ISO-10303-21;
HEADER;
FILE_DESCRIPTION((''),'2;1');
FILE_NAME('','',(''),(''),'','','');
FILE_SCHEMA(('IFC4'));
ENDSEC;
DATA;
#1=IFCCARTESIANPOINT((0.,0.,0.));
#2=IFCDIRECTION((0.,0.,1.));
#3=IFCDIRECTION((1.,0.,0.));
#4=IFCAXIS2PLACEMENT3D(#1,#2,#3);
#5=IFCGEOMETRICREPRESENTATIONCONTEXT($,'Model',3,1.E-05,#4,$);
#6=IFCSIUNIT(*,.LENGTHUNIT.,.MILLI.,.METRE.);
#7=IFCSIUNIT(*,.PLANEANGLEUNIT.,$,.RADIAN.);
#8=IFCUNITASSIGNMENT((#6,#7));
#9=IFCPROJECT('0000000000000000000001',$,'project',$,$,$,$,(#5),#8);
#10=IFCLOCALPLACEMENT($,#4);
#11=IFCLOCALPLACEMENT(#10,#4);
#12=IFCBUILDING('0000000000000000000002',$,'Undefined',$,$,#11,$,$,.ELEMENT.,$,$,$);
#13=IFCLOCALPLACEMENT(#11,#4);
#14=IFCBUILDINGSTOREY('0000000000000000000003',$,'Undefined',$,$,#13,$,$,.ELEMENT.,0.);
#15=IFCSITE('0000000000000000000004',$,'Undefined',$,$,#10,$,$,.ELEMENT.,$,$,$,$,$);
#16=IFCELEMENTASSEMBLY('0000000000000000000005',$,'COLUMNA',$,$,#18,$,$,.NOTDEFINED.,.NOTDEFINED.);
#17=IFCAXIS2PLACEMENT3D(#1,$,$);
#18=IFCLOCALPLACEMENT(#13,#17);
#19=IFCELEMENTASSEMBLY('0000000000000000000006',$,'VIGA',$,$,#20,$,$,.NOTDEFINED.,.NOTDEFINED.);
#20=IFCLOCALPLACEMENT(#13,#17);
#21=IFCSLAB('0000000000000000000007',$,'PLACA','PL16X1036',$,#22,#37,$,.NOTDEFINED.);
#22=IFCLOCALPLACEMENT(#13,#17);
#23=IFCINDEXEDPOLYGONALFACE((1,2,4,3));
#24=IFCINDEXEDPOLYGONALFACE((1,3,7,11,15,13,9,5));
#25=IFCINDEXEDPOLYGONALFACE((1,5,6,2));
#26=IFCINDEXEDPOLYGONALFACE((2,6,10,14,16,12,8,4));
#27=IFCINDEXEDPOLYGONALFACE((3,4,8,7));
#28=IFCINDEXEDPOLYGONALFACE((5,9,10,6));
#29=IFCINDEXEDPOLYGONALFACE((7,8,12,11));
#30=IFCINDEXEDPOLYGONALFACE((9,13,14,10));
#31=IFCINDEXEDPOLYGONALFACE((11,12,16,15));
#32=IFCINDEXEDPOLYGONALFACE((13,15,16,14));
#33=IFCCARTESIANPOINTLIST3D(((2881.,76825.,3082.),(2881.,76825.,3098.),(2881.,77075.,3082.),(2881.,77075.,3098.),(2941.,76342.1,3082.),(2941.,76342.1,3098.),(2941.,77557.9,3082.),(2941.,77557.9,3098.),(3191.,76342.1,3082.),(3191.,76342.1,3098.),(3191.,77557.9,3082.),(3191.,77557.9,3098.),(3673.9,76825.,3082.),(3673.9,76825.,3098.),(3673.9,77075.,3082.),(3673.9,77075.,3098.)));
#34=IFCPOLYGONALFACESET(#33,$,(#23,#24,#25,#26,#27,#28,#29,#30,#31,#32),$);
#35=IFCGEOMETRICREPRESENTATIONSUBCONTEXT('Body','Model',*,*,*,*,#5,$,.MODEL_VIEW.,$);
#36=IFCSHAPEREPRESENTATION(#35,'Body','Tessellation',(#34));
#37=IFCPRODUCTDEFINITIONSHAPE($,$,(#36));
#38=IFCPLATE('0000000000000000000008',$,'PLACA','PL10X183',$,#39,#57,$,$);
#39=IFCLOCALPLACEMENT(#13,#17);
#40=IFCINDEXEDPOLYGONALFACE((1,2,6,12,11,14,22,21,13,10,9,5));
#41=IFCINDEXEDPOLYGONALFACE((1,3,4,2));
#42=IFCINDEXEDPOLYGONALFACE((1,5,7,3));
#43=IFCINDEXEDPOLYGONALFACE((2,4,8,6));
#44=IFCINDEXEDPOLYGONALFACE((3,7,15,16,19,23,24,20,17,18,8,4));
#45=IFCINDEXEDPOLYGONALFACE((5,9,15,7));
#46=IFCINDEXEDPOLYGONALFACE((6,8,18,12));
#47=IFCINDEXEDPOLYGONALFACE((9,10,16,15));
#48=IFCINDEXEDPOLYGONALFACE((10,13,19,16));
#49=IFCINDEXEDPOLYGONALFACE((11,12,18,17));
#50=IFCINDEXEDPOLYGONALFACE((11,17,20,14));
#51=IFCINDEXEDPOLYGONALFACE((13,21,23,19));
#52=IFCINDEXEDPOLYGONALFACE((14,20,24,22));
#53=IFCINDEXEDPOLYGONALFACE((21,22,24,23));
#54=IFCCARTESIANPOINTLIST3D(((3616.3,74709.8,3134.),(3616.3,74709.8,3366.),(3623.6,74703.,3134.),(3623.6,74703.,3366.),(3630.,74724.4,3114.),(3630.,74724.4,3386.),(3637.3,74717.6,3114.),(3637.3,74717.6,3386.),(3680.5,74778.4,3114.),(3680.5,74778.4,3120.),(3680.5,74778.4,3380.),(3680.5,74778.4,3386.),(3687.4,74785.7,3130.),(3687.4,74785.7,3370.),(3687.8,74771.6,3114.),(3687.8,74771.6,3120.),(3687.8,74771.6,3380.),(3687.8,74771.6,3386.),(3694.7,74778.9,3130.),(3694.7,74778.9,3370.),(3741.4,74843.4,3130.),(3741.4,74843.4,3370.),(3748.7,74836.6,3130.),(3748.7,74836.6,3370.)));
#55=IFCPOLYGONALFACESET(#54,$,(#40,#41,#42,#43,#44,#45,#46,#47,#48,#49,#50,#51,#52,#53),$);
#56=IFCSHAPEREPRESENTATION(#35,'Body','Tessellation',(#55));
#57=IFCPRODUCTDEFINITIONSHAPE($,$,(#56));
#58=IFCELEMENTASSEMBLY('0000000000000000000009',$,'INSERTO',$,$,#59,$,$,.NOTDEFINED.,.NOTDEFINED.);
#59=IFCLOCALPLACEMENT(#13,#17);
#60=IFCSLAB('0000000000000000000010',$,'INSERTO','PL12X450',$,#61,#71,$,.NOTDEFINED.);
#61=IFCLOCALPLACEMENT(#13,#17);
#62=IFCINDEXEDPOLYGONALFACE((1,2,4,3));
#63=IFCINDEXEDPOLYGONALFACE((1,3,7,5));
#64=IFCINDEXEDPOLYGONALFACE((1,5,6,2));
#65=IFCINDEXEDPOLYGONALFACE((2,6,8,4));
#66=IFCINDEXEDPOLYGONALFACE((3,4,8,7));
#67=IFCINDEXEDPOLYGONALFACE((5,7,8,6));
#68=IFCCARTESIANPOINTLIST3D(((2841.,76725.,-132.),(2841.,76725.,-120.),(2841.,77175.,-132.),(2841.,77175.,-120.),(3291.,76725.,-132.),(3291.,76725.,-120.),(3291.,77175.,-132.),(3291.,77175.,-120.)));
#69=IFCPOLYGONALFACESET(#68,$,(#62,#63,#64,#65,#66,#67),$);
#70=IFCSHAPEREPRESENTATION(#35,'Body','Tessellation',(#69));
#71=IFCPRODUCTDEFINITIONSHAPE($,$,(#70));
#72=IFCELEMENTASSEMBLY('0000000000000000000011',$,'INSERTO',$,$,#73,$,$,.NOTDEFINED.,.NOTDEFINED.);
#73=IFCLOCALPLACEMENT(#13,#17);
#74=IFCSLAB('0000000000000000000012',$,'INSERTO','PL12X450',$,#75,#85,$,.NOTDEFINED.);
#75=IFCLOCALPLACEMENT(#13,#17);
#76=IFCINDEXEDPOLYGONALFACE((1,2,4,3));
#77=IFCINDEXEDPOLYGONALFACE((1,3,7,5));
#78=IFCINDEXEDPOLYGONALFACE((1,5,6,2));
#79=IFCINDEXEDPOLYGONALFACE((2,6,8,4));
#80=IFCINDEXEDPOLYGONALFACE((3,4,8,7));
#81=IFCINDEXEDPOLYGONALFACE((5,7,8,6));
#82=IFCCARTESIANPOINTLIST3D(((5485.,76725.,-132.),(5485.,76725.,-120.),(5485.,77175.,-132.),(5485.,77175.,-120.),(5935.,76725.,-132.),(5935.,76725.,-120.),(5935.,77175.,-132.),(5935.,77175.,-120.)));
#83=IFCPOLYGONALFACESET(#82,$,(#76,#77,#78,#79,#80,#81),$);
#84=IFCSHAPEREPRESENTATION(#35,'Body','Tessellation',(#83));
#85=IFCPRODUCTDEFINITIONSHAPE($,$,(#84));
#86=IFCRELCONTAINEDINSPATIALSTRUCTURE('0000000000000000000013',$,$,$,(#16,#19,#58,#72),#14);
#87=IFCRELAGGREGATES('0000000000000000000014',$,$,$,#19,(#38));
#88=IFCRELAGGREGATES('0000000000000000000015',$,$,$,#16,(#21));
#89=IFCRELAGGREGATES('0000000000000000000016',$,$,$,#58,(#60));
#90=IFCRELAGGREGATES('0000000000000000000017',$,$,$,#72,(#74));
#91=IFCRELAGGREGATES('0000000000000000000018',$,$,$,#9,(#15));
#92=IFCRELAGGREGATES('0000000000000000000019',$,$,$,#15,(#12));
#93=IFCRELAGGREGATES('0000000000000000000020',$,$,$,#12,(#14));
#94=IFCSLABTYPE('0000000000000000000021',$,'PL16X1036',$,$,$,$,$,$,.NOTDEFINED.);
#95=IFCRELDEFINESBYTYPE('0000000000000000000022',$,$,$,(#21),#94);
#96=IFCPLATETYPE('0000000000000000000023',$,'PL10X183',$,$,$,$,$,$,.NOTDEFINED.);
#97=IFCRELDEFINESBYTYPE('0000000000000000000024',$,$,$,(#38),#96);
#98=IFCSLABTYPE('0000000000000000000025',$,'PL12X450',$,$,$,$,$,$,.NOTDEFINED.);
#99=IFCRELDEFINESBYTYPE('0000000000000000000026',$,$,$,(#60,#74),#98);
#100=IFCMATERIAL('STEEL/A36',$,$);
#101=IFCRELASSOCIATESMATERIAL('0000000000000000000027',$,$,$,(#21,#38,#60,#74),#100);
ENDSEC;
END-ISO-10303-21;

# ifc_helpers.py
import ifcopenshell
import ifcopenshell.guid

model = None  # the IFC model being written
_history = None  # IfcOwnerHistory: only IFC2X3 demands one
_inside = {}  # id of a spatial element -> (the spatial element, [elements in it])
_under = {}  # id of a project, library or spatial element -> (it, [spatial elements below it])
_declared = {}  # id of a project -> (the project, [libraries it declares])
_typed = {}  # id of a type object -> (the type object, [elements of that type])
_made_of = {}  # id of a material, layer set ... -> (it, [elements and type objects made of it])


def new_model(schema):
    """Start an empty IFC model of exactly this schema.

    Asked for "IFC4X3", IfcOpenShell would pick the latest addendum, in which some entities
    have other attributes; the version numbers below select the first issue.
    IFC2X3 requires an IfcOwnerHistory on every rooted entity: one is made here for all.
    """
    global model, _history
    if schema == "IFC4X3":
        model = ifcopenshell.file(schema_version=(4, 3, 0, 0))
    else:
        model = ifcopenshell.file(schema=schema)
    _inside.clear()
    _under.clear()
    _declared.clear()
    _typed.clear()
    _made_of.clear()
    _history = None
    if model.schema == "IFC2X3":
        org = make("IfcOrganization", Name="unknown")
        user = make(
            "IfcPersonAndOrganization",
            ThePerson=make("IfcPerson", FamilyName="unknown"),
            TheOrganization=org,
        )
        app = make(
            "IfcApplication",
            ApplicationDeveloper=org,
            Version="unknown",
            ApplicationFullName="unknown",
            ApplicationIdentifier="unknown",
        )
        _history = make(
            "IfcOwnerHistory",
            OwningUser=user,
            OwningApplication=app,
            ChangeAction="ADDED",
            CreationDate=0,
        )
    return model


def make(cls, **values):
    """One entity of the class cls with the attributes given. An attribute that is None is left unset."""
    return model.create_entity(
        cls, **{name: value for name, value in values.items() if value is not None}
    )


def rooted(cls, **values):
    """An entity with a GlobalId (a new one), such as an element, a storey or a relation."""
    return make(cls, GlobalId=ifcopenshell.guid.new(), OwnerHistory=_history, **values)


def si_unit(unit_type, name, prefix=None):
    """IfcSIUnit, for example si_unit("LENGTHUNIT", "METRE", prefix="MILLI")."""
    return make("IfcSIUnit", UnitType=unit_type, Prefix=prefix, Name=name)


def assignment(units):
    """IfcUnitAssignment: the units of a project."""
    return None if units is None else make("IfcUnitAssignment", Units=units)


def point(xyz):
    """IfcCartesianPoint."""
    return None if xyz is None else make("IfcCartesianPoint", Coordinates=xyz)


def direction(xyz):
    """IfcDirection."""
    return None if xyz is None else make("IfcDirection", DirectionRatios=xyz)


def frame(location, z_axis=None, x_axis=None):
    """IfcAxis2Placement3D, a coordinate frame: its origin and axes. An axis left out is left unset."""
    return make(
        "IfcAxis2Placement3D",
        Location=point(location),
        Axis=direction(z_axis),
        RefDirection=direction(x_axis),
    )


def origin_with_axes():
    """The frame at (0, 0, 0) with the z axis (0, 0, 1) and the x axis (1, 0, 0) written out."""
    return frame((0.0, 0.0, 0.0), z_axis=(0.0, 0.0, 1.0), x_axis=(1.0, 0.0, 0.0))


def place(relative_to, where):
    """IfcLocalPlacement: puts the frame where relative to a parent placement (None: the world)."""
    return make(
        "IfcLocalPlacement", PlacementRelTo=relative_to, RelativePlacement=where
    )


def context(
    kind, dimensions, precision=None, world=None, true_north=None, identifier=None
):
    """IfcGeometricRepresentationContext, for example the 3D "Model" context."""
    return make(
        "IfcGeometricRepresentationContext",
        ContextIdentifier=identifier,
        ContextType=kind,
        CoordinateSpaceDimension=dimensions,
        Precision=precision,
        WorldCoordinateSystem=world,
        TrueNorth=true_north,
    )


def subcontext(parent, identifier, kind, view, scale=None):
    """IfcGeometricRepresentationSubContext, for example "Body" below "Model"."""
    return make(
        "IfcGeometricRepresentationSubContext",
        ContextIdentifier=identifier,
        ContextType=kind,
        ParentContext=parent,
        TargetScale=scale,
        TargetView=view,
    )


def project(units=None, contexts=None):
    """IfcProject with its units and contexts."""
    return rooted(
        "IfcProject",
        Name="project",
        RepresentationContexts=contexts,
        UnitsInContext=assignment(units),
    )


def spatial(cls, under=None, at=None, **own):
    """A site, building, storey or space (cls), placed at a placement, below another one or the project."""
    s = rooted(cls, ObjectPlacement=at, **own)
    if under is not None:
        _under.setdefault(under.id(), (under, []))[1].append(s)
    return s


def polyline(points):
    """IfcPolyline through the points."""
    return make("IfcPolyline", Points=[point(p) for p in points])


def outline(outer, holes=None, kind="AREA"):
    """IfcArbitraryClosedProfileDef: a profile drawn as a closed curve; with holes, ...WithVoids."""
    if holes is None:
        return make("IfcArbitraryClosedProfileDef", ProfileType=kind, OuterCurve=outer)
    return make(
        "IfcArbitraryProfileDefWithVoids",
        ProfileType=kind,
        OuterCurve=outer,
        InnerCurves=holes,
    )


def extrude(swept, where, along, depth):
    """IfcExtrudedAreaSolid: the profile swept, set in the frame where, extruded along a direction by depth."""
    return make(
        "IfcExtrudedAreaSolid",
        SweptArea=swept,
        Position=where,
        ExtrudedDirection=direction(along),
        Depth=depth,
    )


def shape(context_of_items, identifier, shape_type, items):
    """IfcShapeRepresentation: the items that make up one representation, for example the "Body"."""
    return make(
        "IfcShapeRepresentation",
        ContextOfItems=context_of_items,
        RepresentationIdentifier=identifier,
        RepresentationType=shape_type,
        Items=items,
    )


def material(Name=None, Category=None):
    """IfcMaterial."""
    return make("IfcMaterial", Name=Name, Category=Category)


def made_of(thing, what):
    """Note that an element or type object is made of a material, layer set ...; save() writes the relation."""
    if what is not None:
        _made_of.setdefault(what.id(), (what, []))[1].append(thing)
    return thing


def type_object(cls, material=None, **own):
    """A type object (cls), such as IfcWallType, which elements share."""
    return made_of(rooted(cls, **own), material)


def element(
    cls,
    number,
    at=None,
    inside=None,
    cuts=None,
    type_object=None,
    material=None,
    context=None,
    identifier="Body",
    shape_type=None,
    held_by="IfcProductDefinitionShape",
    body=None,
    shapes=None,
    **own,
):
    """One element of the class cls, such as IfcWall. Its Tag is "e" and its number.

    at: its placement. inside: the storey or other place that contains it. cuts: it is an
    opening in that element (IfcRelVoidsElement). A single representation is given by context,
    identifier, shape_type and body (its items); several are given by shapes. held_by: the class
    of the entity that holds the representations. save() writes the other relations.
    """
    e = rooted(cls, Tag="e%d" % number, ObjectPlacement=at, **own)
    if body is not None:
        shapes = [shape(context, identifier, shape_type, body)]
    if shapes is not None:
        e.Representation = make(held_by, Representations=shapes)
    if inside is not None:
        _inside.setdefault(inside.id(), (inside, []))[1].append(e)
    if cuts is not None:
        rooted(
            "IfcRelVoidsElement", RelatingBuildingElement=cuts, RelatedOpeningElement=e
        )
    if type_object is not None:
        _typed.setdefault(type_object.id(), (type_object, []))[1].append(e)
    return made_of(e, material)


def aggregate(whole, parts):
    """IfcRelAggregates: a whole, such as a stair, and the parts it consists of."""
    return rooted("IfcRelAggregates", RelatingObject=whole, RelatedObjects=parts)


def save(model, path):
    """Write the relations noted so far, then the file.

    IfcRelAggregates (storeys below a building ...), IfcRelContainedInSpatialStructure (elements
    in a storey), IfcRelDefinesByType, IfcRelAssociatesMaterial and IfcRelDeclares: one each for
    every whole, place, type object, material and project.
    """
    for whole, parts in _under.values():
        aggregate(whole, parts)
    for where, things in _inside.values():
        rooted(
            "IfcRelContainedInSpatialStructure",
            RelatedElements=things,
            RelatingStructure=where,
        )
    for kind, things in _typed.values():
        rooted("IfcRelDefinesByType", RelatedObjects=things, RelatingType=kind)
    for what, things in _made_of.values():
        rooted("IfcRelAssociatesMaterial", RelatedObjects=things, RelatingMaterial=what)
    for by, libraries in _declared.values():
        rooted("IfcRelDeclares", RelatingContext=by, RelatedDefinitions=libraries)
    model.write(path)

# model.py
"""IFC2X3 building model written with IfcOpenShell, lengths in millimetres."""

from ifc_helpers import new_model, si_unit, frame, origin_with_axes, place, context, subcontext, project, spatial, polyline, outline, extrude, material, type_object, element, aggregate, save


model = new_model("IFC2X3")

# Units and contexts
model_context = context("Model", 3, precision=1e-05, world=origin_with_axes())
body_context = subcontext(model_context, "Body", "Model", "MODEL_VIEW")
ifc_project = project(units=[si_unit("LENGTHUNIT", "METRE", prefix="MILLI"), si_unit("PLANEANGLEUNIT", "RADIAN")], contexts=[model_context])

# Site, building, storey
site_placement = place(None, origin_with_axes())
site = spatial("IfcSite", under=ifc_project, at=site_placement, Name="Undefined", CompositionType="ELEMENT")
building_placement = place(site_placement, origin_with_axes())
building = spatial("IfcBuilding", under=site, at=building_placement, Name="Undefined", CompositionType="ELEMENT")
storey_placement = place(building_placement, origin_with_axes())
storey = spatial("IfcBuildingStorey", under=building, at=storey_placement, Name="Undefined", CompositionType="ELEMENT", Elevation=0.0)

# Element assembly
assembly_1_placement = place(storey_placement, origin_with_axes())
assembly_1 = element("IfcElementAssembly", 1, at=assembly_1_placement, inside=storey, Name="COLUMNA", AssemblyPlace="NOTDEFINED", PredefinedType="NOTDEFINED")
ifc_material_1 = material(Name="STEEL/A36")

# Element assembly
assembly_2_placement = place(storey_placement, origin_with_axes())
assembly_2 = element("IfcElementAssembly", 2, at=assembly_2_placement, inside=storey, Name="VIGA", AssemblyPlace="NOTDEFINED", PredefinedType="NOTDEFINED")

# Slab
slab_type_1 = type_object("IfcSlabType", Name="PL16X1036", PredefinedType="NOTDEFINED")
slab_1_placement = place(assembly_1_placement, frame((3191.0, 76342.1, 3090.0), z_axis=(0.0, 0.0, 1.0), x_axis=(0.707107, 0.707107, 0.0)))
slab_1 = element("IfcSlab", 3, at=slab_1_placement, type_object=slab_type_1, material=ifc_material_1, Name="PLACA", Description="PL16X1036", PredefinedType="NOTDEFINED", context=body_context, shape_type="SweptSolid", body=[
    extrude(outline(polyline([(0.0, 0.0), (682.9, 0.0), (859.7, 176.8), (859.7, 859.7), (682.9, 1036.5), (299.0, 737.4), (122.3, 560.7), (-176.8, 176.8), (0.0, 0.0)])), frame((0.0, 0.0, -8.0), z_axis=(0.0, 0.0, 1.0), x_axis=(1.0, 0.0, 0.0)), (0.0, 0.0, 1.0), 16.0),
])

# Plate
plate_type_1 = type_object("IfcPlateType", Name="PL10X183", PredefinedType="NOTDEFINED")
plate_1_placement = place(assembly_2_placement, frame((3620.0, 74706.4, 3134.0), z_axis=(0.729922, -0.683531, 0.0), x_axis=(0.483329, 0.516132, -0.707107)))
plate_1 = element("IfcPlate", 4, at=plate_1_placement, type_object=plate_type_1, material=ifc_material_1, Name="PLACA", Description="PL10X183", context=body_context, shape_type="SweptSolid", body=[
    extrude(outline(polyline([(0.0, 0.0), (28.3, 0.0), (80.6, 52.3), (76.3, 56.5), (76.3, 70.7), (132.2, 126.6), (-37.5, 296.3), (-93.4, 240.4), (-107.5, 240.4), (-111.8, 244.6), (-164.0, 192.3), (-164.0, 164.0), (0.0, 0.0)])), frame((0.0, 0.0, -5.0), z_axis=(0.0, 0.0, 1.0), x_axis=(1.0, 0.0, 0.0)), (0.0, 0.0, 1.0), 10.0),
])
aggregate(assembly_2, [plate_1])

# Element assemblies, slabs
assembly_3_placement = place(storey_placement, origin_with_axes())
assembly_3 = element("IfcElementAssembly", 5, at=assembly_3_placement, inside=storey, Name="INSERTO", AssemblyPlace="NOTDEFINED", PredefinedType="NOTDEFINED")
slab_type_2 = type_object("IfcSlabType", Name="PL12X450", PredefinedType="NOTDEFINED")
slab_2_placement = place(assembly_3_placement, frame((2841.0, 76725.0, -126.0), z_axis=(0.0, 0.0, 1.0), x_axis=(1.0, 0.0, 0.0)))
slab_2 = element("IfcSlab", 6, at=slab_2_placement, type_object=slab_type_2, material=ifc_material_1, Name="INSERTO", Description="PL12X450", PredefinedType="NOTDEFINED", context=body_context, shape_type="SweptSolid", body=[
    extrude(outline(polyline([(0.0, 0.0), (450.0, 0.0), (450.0, 450.0), (0.0, 450.0), (0.0, 0.0)])), frame((0.0, 0.0, -6.0), z_axis=(0.0, 0.0, 1.0), x_axis=(1.0, 0.0, 0.0)), (0.0, 0.0, 1.0), 12.0),
])
assembly_4_placement = place(storey_placement, origin_with_axes())
assembly_4 = element("IfcElementAssembly", 7, at=assembly_4_placement, inside=storey, Name="INSERTO", AssemblyPlace="NOTDEFINED", PredefinedType="NOTDEFINED")
slab_3_placement = place(assembly_4_placement, frame((5485.0, 76725.0, -126.0), z_axis=(0.0, 0.0, 1.0), x_axis=(1.0, 0.0, 0.0)))
slab_3 = element("IfcSlab", 8, at=slab_3_placement, type_object=slab_type_2, material=ifc_material_1, Name="INSERTO", Description="PL12X450", PredefinedType="NOTDEFINED", context=body_context, shape_type="SweptSolid", body=[
    extrude(outline(polyline([(0.0, 0.0), (450.0, 0.0), (450.0, 450.0), (0.0, 450.0), (0.0, 0.0)])), frame((0.0, 0.0, -6.0), z_axis=(0.0, 0.0, 1.0), x_axis=(1.0, 0.0, 0.0)), (0.0, 0.0, 1.0), 12.0),
])

aggregate(assembly_1, [slab_1])
aggregate(assembly_3, [slab_2])
aggregate(assembly_4, [slab_3])

save(model, "model.ifc")
